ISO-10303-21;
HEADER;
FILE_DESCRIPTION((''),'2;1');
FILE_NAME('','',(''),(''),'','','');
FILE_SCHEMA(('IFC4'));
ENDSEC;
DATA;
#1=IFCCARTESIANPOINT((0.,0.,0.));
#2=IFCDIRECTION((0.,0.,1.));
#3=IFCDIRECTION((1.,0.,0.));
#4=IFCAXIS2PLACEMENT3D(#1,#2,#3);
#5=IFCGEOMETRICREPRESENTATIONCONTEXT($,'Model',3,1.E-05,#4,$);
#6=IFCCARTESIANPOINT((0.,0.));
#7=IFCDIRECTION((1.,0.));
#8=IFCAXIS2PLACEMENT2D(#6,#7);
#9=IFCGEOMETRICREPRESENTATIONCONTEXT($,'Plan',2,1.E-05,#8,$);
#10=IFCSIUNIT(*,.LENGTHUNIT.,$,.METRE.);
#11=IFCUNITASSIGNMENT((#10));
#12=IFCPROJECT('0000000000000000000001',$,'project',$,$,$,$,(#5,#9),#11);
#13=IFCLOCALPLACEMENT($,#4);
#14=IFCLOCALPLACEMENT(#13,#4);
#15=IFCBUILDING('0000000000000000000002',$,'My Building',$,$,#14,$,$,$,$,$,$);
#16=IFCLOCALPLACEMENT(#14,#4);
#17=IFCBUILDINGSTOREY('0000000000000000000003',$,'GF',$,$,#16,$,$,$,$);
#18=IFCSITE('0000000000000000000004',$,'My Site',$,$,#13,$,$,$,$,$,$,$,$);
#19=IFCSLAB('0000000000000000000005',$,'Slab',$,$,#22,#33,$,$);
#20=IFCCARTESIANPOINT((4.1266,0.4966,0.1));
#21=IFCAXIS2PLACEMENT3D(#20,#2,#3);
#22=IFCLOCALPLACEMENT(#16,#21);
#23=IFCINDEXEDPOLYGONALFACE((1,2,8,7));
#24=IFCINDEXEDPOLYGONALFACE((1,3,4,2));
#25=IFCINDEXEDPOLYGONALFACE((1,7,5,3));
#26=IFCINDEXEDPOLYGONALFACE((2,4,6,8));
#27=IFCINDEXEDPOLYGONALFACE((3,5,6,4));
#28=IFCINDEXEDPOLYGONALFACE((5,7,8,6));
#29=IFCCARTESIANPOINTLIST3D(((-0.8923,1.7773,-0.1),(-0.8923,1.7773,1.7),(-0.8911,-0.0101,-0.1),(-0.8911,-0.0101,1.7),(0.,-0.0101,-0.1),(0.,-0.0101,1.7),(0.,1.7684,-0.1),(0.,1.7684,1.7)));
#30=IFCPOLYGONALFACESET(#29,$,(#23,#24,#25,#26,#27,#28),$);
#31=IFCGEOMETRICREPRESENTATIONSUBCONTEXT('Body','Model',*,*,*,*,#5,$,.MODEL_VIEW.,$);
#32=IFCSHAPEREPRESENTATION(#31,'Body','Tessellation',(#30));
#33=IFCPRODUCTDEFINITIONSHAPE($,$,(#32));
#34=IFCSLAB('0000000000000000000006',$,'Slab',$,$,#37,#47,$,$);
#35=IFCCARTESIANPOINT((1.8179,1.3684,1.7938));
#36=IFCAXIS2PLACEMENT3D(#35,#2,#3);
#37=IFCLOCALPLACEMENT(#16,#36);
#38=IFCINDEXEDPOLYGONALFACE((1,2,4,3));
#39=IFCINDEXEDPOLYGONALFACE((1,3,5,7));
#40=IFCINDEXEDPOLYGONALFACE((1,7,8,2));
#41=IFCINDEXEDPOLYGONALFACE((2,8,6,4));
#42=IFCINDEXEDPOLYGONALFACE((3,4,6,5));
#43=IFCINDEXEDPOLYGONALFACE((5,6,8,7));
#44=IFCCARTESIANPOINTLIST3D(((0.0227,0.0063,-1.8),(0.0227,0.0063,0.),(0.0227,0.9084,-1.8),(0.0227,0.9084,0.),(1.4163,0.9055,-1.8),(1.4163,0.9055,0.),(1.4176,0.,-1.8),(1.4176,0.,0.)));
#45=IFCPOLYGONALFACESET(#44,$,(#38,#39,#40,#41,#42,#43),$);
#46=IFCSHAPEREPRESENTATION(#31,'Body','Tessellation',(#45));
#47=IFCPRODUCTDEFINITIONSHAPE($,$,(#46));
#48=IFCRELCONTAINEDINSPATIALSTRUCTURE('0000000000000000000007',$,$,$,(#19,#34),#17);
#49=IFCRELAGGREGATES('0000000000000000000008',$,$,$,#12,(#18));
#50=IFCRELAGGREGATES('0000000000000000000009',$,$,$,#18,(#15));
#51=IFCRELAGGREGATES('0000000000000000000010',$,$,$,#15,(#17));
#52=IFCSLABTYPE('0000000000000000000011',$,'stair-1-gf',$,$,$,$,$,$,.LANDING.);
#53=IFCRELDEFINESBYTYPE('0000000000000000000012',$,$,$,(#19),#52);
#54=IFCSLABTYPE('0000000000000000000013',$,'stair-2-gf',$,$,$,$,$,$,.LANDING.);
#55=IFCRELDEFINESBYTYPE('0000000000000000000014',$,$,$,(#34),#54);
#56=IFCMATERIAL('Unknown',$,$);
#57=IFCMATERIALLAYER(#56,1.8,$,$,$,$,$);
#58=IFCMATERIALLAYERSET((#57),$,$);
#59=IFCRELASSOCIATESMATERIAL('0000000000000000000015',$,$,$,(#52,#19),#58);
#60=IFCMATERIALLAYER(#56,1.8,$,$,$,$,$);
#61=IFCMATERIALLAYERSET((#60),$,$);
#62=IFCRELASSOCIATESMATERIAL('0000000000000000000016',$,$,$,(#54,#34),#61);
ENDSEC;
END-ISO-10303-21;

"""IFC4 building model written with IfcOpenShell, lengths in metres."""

from ifc_helpers import new_model, si_unit, frame, origin_with_axes, origin_2d_with_axis, place, context, subcontext, project, spatial, indexed_curve, outline, extrude, material, layer, layer_set, layer_usage, type_object, element, save


model = new_model("IFC4")

# Units and contexts
model_context = context("Model", 3, precision=1e-05, world=origin_with_axes())
plan_context = context("Plan", 2, precision=1e-05, world=origin_2d_with_axis())
body_context_1 = subcontext(model_context, "Body", "Model", "MODEL_VIEW")
ifc_project = project(units=[si_unit("LENGTHUNIT", "METRE")], contexts=[model_context, plan_context])

# Site, building, storey
site_placement = place(None, origin_with_axes())
site = spatial("IfcSite", under=ifc_project, at=site_placement, Name="My Site")
building_placement = place(site_placement, origin_with_axes())
building = spatial("IfcBuilding", under=site, at=building_placement, Name="My Building")
storey_placement = place(building_placement, origin_with_axes())
storey = spatial("IfcBuildingStorey", under=building, at=storey_placement, Name="GF")

# Shared definitions
ifc_material = material(Name="Unknown")

# Slabs
ifc_layer_1 = layer(ifc_material, 1.8)
ifc_layer_set_1 = layer_set([ifc_layer_1])
ifc_layer_usage_1 = layer_usage(ifc_layer_set_1, "AXIS3", "POSITIVE", -0.1)
slab_type_1 = type_object("IfcSlabType", Name="stair-1-gf", PredefinedType="LANDING", material=ifc_layer_set_1)
slab_1_placement = place(storey_placement, frame((4.1266, 0.4966, 0.1), z_axis=(0.0, 0.0, 1.0), x_axis=(1.0, 0.0, 0.0)))
element("IfcSlab", 1, at=slab_1_placement, inside=storey, type_object=slab_type_1, material=ifc_layer_usage_1, Name="Slab", context=body_context_1, shape_type="SweptSolid", body=[
    extrude(outline(indexed_curve([(0.0, -0.0101), (0.0, 1.7684), (-0.8923, 1.7773), (-0.8911, -0.0101), (0.0, -0.0101)])), frame((0.0, 0.0, -0.1), z_axis=(0.0, 0.0, 1.0), x_axis=(1.0, 0.0, 0.0)), (0.0, 0.0, 1.0), 1.8),
])
ifc_layer_2 = layer(ifc_material, 1.8)
ifc_layer_set_2 = layer_set([ifc_layer_2])
ifc_layer_usage_2 = layer_usage(ifc_layer_set_2, "AXIS3", "POSITIVE", -1.8)
slab_type_2 = type_object("IfcSlabType", Name="stair-2-gf", PredefinedType="LANDING", material=ifc_layer_set_2)
slab_2_placement = place(storey_placement, frame((1.8179, 1.3684, 1.7938), z_axis=(0.0, 0.0, 1.0), x_axis=(1.0, 0.0, 0.0)))
element("IfcSlab", 2, at=slab_2_placement, inside=storey, type_object=slab_type_2, material=ifc_layer_usage_2, Name="Slab", context=body_context_1, shape_type="SweptSolid", body=[
    extrude(outline(indexed_curve([(0.0227, 0.0063), (1.4176, 0.0), (1.4163, 0.9055), (0.0227, 0.9084), (0.0227, 0.0063)])), frame((0.0, 0.0, -1.8), z_axis=(0.0, 0.0, 1.0), x_axis=(1.0, 0.0, 0.0)), (0.0, 0.0, 1.0), 1.8),
])

save(model, "model.ifc")
